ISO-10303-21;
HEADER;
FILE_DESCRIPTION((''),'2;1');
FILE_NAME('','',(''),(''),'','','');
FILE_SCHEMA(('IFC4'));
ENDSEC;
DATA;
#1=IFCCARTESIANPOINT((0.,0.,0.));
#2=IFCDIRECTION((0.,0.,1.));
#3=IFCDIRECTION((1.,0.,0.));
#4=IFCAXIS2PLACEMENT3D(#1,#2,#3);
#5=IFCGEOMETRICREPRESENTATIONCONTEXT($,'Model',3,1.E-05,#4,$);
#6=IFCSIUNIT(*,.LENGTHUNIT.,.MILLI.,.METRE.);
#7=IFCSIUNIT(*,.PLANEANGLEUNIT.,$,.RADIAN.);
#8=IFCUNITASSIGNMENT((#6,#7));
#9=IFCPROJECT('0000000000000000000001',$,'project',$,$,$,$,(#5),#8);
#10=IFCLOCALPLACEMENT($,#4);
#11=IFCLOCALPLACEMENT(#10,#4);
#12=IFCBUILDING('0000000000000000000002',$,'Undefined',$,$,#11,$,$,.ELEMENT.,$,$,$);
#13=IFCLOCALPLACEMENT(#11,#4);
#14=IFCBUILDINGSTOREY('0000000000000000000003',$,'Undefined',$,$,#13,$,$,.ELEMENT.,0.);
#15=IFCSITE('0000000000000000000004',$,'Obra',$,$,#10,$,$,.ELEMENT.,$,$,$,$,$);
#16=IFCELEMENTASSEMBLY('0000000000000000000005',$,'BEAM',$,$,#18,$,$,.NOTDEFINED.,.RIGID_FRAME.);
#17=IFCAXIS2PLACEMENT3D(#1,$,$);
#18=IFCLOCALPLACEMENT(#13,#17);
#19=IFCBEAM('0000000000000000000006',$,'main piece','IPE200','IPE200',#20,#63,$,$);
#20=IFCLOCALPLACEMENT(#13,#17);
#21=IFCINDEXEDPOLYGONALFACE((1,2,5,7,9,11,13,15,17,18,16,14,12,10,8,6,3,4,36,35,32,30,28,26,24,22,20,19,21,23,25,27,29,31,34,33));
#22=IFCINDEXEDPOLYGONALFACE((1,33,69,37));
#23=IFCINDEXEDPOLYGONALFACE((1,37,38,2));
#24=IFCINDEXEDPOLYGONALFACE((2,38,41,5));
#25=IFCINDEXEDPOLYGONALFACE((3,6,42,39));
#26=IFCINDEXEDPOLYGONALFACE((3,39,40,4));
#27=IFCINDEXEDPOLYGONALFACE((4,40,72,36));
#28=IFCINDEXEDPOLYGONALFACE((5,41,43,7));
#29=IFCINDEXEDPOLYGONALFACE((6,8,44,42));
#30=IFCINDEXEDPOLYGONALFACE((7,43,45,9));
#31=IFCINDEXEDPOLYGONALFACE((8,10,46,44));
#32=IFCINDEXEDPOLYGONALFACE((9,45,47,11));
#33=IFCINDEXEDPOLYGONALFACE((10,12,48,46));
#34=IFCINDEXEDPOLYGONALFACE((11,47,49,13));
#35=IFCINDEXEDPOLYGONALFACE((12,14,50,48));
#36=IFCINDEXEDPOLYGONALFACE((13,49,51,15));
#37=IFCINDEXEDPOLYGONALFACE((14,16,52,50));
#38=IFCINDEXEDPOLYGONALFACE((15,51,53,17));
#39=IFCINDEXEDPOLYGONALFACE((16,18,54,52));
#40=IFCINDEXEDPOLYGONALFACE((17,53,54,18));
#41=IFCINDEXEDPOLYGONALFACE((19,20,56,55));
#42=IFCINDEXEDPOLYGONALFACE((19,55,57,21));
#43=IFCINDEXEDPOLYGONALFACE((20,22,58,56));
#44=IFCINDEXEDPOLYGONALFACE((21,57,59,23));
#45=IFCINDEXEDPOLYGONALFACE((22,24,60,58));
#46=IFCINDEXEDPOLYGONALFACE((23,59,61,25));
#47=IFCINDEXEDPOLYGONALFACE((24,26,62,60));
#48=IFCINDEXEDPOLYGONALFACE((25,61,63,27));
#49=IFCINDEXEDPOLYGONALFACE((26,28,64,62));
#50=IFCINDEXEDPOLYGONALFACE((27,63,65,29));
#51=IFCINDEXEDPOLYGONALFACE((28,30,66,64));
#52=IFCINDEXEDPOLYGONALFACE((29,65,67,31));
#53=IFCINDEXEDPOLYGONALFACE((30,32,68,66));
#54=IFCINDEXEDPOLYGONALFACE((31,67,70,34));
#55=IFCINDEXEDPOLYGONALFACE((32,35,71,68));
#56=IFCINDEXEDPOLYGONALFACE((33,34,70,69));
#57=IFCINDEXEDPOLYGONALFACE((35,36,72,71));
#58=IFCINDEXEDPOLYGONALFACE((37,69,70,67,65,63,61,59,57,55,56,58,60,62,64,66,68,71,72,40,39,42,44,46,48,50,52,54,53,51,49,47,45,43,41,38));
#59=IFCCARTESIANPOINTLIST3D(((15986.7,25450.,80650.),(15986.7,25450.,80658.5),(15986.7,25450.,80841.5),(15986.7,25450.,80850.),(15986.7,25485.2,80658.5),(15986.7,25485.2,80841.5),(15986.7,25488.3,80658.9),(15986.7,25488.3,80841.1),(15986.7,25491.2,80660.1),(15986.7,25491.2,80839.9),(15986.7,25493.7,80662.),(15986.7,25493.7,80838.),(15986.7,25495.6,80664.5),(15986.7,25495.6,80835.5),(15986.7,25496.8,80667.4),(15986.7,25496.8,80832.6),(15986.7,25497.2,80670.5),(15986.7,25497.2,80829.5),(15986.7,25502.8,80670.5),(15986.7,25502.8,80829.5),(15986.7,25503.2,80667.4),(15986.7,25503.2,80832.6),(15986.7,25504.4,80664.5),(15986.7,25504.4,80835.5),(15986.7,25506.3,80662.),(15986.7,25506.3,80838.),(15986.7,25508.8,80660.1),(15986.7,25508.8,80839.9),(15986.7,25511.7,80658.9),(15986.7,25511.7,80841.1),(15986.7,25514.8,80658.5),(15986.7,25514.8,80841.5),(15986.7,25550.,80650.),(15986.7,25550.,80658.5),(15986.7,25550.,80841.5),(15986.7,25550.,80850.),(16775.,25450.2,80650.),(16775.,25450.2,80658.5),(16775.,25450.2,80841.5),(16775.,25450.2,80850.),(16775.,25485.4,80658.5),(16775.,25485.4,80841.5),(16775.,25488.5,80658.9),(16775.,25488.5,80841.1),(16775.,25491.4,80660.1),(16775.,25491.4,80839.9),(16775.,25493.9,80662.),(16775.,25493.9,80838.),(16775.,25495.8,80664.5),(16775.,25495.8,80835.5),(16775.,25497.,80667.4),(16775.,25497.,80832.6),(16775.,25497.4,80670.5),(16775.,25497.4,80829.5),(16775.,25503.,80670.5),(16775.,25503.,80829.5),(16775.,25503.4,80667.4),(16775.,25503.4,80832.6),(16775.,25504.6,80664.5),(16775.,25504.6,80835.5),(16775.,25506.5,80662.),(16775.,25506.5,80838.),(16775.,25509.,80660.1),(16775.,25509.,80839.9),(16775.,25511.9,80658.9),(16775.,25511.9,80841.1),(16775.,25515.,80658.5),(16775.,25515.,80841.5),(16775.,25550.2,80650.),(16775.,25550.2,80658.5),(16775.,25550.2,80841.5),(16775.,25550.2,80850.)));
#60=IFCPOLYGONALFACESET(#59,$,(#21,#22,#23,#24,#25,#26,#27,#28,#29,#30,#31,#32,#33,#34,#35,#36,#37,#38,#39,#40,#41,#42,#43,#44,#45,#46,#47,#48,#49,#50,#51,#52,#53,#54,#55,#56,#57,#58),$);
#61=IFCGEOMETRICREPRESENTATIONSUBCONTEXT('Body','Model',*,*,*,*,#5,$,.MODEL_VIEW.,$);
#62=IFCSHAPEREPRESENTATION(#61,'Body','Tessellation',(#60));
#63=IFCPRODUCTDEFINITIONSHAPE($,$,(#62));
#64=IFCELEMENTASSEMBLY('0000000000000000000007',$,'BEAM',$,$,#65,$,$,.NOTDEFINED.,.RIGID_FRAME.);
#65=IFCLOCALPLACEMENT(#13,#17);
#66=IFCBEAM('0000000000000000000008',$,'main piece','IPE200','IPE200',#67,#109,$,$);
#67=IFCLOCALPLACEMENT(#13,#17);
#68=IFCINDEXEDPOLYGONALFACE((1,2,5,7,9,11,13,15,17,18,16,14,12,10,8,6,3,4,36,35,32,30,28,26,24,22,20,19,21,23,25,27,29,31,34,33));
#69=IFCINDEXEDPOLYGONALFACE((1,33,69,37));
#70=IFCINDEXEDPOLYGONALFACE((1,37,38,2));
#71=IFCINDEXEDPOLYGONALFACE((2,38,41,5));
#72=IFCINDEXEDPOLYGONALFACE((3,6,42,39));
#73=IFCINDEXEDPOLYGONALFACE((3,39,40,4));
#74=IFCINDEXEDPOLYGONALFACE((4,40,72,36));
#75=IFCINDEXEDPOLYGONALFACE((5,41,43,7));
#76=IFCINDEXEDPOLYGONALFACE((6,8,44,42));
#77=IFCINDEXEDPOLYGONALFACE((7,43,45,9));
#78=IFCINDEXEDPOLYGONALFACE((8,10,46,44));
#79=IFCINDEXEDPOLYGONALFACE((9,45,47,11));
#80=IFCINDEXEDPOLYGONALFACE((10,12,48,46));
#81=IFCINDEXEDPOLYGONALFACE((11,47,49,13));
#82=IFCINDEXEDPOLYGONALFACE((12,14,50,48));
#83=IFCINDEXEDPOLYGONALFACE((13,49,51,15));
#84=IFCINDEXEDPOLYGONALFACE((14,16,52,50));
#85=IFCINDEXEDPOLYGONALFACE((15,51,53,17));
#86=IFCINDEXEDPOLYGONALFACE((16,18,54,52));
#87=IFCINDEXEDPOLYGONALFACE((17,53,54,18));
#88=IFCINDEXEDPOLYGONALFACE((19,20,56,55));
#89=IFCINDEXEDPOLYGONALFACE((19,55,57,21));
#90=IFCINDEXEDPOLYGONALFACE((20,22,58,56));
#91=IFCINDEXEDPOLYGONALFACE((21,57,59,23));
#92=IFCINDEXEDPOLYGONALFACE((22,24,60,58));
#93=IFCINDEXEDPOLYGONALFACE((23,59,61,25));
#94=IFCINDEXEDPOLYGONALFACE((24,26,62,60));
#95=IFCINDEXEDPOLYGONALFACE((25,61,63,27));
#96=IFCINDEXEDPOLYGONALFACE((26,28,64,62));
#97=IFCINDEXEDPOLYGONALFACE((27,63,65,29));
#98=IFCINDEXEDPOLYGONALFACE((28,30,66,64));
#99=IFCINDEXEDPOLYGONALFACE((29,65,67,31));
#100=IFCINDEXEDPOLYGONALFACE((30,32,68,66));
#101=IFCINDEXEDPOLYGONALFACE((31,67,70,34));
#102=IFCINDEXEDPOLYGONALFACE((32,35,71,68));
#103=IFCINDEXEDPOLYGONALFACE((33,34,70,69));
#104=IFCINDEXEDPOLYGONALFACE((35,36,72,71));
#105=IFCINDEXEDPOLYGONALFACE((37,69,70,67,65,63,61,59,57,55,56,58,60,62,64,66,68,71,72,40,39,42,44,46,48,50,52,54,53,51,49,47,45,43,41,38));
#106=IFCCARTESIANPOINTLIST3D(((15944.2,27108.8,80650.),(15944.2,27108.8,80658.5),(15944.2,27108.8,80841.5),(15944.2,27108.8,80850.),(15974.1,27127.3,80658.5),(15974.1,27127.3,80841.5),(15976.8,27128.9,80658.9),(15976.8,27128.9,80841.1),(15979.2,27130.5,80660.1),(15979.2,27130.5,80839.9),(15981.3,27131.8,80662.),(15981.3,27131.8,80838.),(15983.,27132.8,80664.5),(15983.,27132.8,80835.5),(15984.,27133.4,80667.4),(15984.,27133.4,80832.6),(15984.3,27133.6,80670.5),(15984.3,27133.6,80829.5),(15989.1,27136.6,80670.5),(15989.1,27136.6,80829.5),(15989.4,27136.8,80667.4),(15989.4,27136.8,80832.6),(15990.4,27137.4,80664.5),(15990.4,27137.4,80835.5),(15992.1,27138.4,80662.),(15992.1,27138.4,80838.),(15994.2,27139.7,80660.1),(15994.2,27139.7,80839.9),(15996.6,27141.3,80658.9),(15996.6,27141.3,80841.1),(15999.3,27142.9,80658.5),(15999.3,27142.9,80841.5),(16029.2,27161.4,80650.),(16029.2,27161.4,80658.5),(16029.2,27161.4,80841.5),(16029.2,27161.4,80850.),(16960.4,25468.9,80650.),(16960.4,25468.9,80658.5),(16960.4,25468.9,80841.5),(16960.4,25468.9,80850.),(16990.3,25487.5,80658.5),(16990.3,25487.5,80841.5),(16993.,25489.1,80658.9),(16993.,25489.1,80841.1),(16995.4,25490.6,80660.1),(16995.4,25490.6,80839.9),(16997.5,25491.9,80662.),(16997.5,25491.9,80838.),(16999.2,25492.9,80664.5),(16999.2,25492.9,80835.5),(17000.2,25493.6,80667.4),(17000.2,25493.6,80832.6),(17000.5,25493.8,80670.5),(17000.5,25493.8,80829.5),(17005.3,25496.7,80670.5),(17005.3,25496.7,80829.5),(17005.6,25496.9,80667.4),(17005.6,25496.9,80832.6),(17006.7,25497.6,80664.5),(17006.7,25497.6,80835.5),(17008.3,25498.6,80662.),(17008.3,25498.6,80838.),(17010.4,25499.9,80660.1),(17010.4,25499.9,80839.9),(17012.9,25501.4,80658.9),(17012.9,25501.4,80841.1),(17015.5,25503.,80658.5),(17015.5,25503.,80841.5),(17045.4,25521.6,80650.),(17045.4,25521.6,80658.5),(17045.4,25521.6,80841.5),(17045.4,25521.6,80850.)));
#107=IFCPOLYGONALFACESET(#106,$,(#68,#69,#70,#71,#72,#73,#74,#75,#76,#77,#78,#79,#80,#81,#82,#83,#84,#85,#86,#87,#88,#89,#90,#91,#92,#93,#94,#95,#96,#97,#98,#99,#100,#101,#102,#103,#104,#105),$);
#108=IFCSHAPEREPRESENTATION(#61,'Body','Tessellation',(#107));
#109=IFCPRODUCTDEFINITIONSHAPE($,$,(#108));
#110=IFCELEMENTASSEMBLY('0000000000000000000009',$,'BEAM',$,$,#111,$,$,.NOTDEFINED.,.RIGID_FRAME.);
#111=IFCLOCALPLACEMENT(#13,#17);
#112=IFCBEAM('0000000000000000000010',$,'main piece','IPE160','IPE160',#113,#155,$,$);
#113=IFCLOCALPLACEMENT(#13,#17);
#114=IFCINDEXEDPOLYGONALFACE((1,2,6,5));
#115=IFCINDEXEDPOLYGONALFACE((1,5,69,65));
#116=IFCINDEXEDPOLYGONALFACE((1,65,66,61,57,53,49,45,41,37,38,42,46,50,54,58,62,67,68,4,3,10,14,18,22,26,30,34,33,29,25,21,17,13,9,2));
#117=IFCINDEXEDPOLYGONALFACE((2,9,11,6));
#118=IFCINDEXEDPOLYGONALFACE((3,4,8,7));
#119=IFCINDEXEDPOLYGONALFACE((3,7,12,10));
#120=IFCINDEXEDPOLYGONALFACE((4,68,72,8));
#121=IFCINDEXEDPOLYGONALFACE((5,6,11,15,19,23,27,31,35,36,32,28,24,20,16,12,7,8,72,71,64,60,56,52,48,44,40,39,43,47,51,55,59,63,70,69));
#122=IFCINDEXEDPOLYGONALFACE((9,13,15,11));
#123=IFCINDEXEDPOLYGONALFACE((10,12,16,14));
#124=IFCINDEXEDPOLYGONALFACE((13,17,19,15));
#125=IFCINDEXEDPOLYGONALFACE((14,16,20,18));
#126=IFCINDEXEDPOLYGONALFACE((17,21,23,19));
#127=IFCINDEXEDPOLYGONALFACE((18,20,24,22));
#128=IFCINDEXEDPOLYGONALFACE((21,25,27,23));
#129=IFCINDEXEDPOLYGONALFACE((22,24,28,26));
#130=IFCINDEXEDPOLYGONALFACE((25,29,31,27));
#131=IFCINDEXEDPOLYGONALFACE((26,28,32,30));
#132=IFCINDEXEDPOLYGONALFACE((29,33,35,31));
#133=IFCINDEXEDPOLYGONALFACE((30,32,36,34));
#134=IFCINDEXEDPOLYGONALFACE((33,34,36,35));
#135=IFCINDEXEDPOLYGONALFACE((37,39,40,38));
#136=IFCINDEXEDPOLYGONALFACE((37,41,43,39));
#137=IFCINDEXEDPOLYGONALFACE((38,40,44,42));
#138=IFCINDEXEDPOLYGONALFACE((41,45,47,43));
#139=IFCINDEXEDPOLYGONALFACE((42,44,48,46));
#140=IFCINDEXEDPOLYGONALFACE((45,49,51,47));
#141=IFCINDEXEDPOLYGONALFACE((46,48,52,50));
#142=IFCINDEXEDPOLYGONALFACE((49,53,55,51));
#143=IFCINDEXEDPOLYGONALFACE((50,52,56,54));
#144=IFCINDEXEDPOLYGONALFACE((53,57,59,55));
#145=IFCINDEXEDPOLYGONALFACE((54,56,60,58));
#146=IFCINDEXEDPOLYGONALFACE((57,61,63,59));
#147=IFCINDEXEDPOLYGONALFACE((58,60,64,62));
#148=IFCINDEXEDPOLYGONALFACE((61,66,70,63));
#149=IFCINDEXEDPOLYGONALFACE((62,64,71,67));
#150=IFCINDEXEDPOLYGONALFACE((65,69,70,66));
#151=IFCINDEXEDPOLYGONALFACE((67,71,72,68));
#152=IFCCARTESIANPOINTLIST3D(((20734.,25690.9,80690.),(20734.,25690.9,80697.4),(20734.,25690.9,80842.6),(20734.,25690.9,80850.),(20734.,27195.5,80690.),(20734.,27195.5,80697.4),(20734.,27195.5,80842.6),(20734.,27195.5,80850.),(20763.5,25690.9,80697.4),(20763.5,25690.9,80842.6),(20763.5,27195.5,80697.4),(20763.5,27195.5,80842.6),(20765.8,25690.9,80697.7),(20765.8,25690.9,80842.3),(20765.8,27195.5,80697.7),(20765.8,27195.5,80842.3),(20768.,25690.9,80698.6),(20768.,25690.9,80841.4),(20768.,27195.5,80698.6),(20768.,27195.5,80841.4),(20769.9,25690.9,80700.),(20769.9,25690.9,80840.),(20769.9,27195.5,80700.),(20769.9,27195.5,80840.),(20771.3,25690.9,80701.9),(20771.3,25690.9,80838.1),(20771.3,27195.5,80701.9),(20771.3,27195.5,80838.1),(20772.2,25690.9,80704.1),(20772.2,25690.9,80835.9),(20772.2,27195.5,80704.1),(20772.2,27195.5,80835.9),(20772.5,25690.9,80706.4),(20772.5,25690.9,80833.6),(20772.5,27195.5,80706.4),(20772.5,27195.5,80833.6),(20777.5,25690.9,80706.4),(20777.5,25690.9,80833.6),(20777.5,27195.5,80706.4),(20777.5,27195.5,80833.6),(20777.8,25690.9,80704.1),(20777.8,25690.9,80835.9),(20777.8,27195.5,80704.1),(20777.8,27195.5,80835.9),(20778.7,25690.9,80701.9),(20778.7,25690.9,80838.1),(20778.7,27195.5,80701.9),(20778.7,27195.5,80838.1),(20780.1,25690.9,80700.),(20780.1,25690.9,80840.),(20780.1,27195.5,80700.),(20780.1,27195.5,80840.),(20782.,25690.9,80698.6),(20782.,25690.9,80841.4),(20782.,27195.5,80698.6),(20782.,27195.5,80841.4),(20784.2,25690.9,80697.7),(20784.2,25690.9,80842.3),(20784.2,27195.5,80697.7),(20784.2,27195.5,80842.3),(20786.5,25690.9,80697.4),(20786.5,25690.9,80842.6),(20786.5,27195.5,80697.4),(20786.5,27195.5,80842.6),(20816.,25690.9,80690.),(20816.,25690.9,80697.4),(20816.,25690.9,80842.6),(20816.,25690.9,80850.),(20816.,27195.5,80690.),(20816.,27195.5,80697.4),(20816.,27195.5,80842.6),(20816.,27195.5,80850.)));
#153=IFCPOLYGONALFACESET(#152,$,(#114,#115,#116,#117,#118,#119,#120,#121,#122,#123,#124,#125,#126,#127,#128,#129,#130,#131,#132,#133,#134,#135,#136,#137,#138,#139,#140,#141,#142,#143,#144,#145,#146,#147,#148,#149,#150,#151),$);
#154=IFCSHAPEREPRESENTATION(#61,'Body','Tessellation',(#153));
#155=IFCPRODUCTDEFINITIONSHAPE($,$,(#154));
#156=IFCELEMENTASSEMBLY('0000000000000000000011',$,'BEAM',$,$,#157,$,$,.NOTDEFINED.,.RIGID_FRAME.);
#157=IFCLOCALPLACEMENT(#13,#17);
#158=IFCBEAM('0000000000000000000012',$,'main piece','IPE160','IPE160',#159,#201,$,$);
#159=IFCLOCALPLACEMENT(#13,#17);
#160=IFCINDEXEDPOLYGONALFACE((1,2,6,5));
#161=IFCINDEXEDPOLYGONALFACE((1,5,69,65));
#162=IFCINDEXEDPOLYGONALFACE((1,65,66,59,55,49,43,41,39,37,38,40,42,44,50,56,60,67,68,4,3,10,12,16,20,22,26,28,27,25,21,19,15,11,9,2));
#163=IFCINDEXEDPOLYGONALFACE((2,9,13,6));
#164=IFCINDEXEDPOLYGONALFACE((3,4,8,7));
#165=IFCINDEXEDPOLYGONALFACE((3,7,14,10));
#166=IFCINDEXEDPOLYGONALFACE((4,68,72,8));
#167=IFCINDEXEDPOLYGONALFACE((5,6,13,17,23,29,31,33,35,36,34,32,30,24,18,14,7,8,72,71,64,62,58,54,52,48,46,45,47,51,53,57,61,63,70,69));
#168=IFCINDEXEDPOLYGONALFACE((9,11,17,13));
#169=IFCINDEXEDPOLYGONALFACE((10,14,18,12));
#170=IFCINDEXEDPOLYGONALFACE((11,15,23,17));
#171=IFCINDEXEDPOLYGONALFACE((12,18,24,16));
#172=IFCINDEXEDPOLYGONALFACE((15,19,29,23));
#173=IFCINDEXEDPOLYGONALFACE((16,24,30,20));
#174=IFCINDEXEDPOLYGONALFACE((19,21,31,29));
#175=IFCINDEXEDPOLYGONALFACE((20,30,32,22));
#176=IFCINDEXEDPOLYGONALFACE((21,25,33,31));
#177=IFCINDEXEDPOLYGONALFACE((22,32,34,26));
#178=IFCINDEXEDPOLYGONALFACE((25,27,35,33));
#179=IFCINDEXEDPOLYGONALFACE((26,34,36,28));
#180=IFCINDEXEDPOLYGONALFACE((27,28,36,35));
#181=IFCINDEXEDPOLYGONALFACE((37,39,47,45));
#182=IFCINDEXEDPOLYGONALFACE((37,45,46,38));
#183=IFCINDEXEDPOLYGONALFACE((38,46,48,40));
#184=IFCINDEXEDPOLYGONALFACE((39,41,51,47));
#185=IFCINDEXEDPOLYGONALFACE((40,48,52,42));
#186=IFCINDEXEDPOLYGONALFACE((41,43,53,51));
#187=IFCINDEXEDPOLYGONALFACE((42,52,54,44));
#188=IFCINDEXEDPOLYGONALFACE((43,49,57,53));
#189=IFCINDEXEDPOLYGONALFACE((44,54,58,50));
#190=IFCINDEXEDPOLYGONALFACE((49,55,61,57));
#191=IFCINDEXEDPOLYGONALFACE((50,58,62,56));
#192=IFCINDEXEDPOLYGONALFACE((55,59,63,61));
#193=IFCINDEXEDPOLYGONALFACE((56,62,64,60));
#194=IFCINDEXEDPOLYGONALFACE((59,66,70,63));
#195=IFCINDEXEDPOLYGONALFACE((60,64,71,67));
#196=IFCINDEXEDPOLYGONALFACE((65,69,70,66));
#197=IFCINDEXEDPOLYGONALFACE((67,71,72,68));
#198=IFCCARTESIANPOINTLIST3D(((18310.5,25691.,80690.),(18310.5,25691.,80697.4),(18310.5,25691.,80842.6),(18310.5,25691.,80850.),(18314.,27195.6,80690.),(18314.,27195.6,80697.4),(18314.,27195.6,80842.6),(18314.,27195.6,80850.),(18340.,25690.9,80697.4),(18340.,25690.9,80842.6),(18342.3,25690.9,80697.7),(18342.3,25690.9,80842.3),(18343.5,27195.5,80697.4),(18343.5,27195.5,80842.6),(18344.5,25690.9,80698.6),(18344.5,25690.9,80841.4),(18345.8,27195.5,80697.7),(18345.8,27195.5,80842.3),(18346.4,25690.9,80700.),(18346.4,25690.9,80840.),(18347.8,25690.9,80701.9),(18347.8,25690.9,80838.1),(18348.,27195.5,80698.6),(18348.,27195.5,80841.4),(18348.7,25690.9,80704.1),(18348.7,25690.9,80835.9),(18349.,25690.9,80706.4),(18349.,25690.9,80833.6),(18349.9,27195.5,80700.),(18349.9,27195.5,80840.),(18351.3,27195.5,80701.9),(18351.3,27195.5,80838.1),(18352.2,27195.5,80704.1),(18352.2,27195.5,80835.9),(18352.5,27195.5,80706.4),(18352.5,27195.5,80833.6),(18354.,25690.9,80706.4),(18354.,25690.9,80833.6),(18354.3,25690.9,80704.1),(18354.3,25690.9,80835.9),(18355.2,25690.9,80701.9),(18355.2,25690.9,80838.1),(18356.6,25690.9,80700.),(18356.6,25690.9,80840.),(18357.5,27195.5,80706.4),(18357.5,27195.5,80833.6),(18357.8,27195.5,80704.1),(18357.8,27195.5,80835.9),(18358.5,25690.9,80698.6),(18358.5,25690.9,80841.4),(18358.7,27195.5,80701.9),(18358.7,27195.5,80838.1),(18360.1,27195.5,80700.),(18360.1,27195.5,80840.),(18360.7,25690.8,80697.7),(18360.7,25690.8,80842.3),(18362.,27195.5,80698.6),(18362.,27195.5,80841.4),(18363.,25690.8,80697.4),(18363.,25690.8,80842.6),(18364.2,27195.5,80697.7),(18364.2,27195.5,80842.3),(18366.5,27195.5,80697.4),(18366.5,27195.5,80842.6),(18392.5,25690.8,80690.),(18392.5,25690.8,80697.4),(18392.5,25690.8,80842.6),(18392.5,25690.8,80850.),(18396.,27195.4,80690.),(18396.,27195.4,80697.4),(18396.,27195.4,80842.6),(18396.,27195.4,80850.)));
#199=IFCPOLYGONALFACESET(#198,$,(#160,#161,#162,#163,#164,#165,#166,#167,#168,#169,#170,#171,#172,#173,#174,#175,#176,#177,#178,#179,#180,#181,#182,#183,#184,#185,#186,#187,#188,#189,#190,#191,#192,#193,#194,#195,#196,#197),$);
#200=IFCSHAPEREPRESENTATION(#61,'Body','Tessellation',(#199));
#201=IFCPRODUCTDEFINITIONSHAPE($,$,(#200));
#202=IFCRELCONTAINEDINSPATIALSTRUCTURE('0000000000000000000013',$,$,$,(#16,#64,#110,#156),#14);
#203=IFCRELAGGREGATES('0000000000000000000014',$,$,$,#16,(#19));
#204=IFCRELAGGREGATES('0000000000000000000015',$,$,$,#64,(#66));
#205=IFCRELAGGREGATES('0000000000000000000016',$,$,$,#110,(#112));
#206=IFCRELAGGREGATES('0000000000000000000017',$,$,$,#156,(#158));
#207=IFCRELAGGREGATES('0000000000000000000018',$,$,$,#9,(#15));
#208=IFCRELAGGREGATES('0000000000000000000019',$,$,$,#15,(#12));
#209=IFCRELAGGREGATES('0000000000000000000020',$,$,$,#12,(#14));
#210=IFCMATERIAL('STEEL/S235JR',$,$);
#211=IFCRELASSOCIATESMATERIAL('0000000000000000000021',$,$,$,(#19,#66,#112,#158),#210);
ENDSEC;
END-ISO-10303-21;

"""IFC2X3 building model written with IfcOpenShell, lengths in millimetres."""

from ifc_helpers import new_model, si_unit, frame, origin_with_axes, origin_2d_with_axis, place, context, subcontext, project, spatial, i_section, extrude, material, element, aggregate, save


model = new_model("IFC2X3")

# Units and contexts
model_context = context("Model", 3, precision=1e-05, world=origin_with_axes())
body_context = subcontext(model_context, "Body", "Model", "MODEL_VIEW")
ifc_project = project(units=[si_unit("LENGTHUNIT", "METRE", prefix="MILLI"), si_unit("PLANEANGLEUNIT", "RADIAN")], contexts=[model_context])

# Site, building, storey
site_placement = place(None, origin_with_axes())
site = spatial("IfcSite", under=ifc_project, at=site_placement, Name="Obra", CompositionType="ELEMENT")
building_placement = place(site_placement, origin_with_axes())
building = spatial("IfcBuilding", under=site, at=building_placement, Name="Undefined", CompositionType="ELEMENT")
storey_placement = place(building_placement, origin_with_axes())
storey = spatial("IfcBuildingStorey", under=building, at=storey_placement, Name="Undefined", CompositionType="ELEMENT", Elevation=0.0)

# Element assemblies, beams
ifc_material = material(Name="STEEL/S235JR")
assembly_1_placement = place(storey_placement, origin_with_axes())
assembly_1 = element("IfcElementAssembly", 1, at=assembly_1_placement, inside=storey, Name="BEAM", AssemblyPlace="NOTDEFINED", PredefinedType="RIGID_FRAME")
beam_1_placement = place(assembly_1_placement, frame((16775.0, 25500.2, 80750.0), z_axis=(0.0, 0.0, 1.0), x_axis=(-1.0, -0.000266, 0.0)))
beam_1 = element("IfcBeam", 2, at=beam_1_placement, material=ifc_material, Name="main piece", Description="IPE200", ObjectType="IPE200", context=body_context, shape_type="SweptSolid", body=[
    extrude(i_section(OverallWidth=100.0, OverallDepth=200.0, WebThickness=5.6, FlangeThickness=8.5, FilletRadius=12.0, at=origin_2d_with_axis()), frame((788.3, 0.0, 0.0), z_axis=(-1.0, 0.0, 0.0), x_axis=(0.0, -1.0, 0.0)), (0.0, 0.0, 1.0), 788.3),
])
aggregate(assembly_1, [beam_1])
assembly_2_placement = place(storey_placement, origin_with_axes())
assembly_2 = element("IfcElementAssembly", 3, at=assembly_2_placement, inside=storey, Name="BEAM", AssemblyPlace="NOTDEFINED", PredefinedType="RIGID_FRAME")
beam_2_placement = place(assembly_2_placement, frame((17002.9, 25495.3, 80750.0), z_axis=(0.0, 0.0, 1.0), x_axis=(-0.526756, 0.850017, 0.0)))
beam_2 = element("IfcBeam", 4, at=beam_2_placement, material=ifc_material, Name="main piece", Description="IPE200", ObjectType="IPE200", context=body_context, shape_type="SweptSolid", body=[
    extrude(i_section(OverallWidth=100.0, OverallDepth=200.0, WebThickness=5.6, FlangeThickness=8.5, FilletRadius=12.0, at=origin_2d_with_axis()), frame((1929.2, 0.0, 0.0), z_axis=(-1.0, 0.0, 0.0), x_axis=(0.0, -1.0, 0.0)), (0.0, 0.0, 1.0), 1929.2),
])
aggregate(assembly_2, [beam_2])
assembly_3_placement = place(storey_placement, origin_with_axes())
assembly_3 = element("IfcElementAssembly", 5, at=assembly_3_placement, inside=storey, Name="BEAM", AssemblyPlace="NOTDEFINED", PredefinedType="RIGID_FRAME")
beam_3_placement = place(assembly_3_placement, frame((20775.0, 25690.9, 80770.0), z_axis=(0.0, 0.0, 1.0), x_axis=(0.0, 1.0, 0.0)))
beam_3 = element("IfcBeam", 6, at=beam_3_placement, material=ifc_material, Name="main piece", Description="IPE160", ObjectType="IPE160", context=body_context, shape_type="SweptSolid", body=[
    extrude(i_section(OverallWidth=82.0, OverallDepth=160.0, WebThickness=5.0, FlangeThickness=7.4, FilletRadius=9.0, at=origin_2d_with_axis()), frame((1504.6, 0.0, 0.0), z_axis=(-1.0, 0.0, 0.0), x_axis=(0.0, -1.0, 0.0)), (0.0, 0.0, 1.0), 1504.6),
])
aggregate(assembly_3, [beam_3])
assembly_4_placement = place(storey_placement, origin_with_axes())
assembly_4 = element("IfcElementAssembly", 7, at=assembly_4_placement, inside=storey, Name="BEAM", AssemblyPlace="NOTDEFINED", PredefinedType="RIGID_FRAME")
beam_4_placement = place(assembly_4_placement, frame((18351.5, 25690.9, 80770.0), z_axis=(0.0, 0.0, 1.0), x_axis=(0.002325, 0.999997, 0.0)))
beam_4 = element("IfcBeam", 8, at=beam_4_placement, material=ifc_material, Name="main piece", Description="IPE160", ObjectType="IPE160", context=body_context, shape_type="SweptSolid", body=[
    extrude(i_section(OverallWidth=82.0, OverallDepth=160.0, WebThickness=5.0, FlangeThickness=7.4, FilletRadius=9.0, at=origin_2d_with_axis()), frame((1504.6, 0.0, 0.0), z_axis=(-1.0, 0.0, 0.0), x_axis=(0.0, -1.0, 0.0)), (0.0, 0.0, 1.0), 1504.6),
])
aggregate(assembly_4, [beam_4])

save(model, "model.ifc")
